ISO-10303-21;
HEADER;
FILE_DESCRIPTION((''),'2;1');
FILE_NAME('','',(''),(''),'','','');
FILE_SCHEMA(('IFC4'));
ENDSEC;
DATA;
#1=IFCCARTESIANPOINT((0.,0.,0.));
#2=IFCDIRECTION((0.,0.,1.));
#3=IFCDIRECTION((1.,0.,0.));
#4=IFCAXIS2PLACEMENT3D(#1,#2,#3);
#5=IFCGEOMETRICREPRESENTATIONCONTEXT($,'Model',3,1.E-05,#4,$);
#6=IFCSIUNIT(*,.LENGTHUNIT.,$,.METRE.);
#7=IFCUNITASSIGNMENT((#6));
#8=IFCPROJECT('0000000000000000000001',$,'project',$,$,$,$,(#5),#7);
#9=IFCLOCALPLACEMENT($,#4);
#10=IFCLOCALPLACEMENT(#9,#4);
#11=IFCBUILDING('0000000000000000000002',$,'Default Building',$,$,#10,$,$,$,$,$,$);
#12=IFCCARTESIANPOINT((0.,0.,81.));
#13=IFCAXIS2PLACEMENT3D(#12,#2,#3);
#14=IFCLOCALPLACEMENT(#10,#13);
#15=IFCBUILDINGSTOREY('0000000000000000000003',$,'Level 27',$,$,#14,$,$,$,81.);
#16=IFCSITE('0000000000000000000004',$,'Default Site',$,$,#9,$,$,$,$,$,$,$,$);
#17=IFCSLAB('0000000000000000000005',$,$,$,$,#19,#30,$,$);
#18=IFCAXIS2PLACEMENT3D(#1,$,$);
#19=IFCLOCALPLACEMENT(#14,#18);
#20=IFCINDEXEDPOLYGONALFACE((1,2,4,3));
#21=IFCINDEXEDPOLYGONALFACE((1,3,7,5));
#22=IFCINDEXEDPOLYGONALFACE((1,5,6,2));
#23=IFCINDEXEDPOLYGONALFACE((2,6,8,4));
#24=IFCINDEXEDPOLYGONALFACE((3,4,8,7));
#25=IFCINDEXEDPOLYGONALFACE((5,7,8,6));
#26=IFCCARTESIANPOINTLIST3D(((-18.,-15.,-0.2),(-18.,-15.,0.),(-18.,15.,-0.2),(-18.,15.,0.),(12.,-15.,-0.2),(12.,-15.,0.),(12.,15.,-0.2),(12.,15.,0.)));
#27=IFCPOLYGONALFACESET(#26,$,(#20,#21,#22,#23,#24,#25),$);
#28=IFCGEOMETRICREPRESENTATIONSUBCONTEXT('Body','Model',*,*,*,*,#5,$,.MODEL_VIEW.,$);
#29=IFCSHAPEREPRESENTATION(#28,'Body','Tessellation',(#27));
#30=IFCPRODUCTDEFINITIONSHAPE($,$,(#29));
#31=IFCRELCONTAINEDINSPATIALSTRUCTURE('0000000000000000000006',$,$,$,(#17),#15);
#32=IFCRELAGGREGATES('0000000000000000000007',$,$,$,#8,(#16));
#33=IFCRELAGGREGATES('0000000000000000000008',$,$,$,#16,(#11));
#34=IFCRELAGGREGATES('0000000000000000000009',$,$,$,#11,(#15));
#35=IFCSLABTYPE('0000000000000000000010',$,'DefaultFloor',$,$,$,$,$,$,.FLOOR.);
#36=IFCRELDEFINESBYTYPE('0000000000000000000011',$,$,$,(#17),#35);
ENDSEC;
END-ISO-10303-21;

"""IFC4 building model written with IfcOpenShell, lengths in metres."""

from ifc_helpers import new_model, si_unit, frame, origin_with_axes, place, context, subcontext, project, spatial, polyline, outline, extrude, type_object, element, save


model = new_model("IFC4")

# Units and contexts
model_context = context("Model", 3, precision=1e-05, world=origin_with_axes())
body_context = subcontext(model_context, "Body", "Model", "MODEL_VIEW")
ifc_project = project(units=[si_unit("LENGTHUNIT", "METRE")], contexts=[model_context])

# Site, building, storey
site_placement = place(None, origin_with_axes())
site = spatial("IfcSite", under=ifc_project, at=site_placement, Name="Default Site")
building_placement = place(site_placement, origin_with_axes())
building = spatial("IfcBuilding", under=site, at=building_placement, Name="Default Building")
storey_placement = place(building_placement, frame((0.0, 0.0, 81.0), z_axis=(0.0, 0.0, 1.0), x_axis=(1.0, 0.0, 0.0)))
storey = spatial("IfcBuildingStorey", under=building, at=storey_placement, Name="Level 27", Elevation=81.0)

# Slab
slab_type = type_object("IfcSlabType", Name="DefaultFloor", PredefinedType="FLOOR")
slab_placement = place(storey_placement, frame((0.0, 0.0, -81.0), z_axis=(0.0, 0.0, 1.0), x_axis=(1.0, 0.0, 0.0)))
element("IfcSlab", 1, at=slab_placement, inside=storey, type_object=slab_type, context=body_context, shape_type="SweptSolid", body=[
    extrude(outline(polyline([(-18.0, 15.0), (12.0, 15.0), (12.0, -15.0), (-18.0, -15.0), (-18.0, 15.0)])), frame((0.0, 0.0, 81.0), z_axis=(0.0, 0.0, 1.0), x_axis=(1.0, 0.0, 0.0)), (0.0, 0.0, -1.0), 0.2),
])

save(model, "model.ifc")
